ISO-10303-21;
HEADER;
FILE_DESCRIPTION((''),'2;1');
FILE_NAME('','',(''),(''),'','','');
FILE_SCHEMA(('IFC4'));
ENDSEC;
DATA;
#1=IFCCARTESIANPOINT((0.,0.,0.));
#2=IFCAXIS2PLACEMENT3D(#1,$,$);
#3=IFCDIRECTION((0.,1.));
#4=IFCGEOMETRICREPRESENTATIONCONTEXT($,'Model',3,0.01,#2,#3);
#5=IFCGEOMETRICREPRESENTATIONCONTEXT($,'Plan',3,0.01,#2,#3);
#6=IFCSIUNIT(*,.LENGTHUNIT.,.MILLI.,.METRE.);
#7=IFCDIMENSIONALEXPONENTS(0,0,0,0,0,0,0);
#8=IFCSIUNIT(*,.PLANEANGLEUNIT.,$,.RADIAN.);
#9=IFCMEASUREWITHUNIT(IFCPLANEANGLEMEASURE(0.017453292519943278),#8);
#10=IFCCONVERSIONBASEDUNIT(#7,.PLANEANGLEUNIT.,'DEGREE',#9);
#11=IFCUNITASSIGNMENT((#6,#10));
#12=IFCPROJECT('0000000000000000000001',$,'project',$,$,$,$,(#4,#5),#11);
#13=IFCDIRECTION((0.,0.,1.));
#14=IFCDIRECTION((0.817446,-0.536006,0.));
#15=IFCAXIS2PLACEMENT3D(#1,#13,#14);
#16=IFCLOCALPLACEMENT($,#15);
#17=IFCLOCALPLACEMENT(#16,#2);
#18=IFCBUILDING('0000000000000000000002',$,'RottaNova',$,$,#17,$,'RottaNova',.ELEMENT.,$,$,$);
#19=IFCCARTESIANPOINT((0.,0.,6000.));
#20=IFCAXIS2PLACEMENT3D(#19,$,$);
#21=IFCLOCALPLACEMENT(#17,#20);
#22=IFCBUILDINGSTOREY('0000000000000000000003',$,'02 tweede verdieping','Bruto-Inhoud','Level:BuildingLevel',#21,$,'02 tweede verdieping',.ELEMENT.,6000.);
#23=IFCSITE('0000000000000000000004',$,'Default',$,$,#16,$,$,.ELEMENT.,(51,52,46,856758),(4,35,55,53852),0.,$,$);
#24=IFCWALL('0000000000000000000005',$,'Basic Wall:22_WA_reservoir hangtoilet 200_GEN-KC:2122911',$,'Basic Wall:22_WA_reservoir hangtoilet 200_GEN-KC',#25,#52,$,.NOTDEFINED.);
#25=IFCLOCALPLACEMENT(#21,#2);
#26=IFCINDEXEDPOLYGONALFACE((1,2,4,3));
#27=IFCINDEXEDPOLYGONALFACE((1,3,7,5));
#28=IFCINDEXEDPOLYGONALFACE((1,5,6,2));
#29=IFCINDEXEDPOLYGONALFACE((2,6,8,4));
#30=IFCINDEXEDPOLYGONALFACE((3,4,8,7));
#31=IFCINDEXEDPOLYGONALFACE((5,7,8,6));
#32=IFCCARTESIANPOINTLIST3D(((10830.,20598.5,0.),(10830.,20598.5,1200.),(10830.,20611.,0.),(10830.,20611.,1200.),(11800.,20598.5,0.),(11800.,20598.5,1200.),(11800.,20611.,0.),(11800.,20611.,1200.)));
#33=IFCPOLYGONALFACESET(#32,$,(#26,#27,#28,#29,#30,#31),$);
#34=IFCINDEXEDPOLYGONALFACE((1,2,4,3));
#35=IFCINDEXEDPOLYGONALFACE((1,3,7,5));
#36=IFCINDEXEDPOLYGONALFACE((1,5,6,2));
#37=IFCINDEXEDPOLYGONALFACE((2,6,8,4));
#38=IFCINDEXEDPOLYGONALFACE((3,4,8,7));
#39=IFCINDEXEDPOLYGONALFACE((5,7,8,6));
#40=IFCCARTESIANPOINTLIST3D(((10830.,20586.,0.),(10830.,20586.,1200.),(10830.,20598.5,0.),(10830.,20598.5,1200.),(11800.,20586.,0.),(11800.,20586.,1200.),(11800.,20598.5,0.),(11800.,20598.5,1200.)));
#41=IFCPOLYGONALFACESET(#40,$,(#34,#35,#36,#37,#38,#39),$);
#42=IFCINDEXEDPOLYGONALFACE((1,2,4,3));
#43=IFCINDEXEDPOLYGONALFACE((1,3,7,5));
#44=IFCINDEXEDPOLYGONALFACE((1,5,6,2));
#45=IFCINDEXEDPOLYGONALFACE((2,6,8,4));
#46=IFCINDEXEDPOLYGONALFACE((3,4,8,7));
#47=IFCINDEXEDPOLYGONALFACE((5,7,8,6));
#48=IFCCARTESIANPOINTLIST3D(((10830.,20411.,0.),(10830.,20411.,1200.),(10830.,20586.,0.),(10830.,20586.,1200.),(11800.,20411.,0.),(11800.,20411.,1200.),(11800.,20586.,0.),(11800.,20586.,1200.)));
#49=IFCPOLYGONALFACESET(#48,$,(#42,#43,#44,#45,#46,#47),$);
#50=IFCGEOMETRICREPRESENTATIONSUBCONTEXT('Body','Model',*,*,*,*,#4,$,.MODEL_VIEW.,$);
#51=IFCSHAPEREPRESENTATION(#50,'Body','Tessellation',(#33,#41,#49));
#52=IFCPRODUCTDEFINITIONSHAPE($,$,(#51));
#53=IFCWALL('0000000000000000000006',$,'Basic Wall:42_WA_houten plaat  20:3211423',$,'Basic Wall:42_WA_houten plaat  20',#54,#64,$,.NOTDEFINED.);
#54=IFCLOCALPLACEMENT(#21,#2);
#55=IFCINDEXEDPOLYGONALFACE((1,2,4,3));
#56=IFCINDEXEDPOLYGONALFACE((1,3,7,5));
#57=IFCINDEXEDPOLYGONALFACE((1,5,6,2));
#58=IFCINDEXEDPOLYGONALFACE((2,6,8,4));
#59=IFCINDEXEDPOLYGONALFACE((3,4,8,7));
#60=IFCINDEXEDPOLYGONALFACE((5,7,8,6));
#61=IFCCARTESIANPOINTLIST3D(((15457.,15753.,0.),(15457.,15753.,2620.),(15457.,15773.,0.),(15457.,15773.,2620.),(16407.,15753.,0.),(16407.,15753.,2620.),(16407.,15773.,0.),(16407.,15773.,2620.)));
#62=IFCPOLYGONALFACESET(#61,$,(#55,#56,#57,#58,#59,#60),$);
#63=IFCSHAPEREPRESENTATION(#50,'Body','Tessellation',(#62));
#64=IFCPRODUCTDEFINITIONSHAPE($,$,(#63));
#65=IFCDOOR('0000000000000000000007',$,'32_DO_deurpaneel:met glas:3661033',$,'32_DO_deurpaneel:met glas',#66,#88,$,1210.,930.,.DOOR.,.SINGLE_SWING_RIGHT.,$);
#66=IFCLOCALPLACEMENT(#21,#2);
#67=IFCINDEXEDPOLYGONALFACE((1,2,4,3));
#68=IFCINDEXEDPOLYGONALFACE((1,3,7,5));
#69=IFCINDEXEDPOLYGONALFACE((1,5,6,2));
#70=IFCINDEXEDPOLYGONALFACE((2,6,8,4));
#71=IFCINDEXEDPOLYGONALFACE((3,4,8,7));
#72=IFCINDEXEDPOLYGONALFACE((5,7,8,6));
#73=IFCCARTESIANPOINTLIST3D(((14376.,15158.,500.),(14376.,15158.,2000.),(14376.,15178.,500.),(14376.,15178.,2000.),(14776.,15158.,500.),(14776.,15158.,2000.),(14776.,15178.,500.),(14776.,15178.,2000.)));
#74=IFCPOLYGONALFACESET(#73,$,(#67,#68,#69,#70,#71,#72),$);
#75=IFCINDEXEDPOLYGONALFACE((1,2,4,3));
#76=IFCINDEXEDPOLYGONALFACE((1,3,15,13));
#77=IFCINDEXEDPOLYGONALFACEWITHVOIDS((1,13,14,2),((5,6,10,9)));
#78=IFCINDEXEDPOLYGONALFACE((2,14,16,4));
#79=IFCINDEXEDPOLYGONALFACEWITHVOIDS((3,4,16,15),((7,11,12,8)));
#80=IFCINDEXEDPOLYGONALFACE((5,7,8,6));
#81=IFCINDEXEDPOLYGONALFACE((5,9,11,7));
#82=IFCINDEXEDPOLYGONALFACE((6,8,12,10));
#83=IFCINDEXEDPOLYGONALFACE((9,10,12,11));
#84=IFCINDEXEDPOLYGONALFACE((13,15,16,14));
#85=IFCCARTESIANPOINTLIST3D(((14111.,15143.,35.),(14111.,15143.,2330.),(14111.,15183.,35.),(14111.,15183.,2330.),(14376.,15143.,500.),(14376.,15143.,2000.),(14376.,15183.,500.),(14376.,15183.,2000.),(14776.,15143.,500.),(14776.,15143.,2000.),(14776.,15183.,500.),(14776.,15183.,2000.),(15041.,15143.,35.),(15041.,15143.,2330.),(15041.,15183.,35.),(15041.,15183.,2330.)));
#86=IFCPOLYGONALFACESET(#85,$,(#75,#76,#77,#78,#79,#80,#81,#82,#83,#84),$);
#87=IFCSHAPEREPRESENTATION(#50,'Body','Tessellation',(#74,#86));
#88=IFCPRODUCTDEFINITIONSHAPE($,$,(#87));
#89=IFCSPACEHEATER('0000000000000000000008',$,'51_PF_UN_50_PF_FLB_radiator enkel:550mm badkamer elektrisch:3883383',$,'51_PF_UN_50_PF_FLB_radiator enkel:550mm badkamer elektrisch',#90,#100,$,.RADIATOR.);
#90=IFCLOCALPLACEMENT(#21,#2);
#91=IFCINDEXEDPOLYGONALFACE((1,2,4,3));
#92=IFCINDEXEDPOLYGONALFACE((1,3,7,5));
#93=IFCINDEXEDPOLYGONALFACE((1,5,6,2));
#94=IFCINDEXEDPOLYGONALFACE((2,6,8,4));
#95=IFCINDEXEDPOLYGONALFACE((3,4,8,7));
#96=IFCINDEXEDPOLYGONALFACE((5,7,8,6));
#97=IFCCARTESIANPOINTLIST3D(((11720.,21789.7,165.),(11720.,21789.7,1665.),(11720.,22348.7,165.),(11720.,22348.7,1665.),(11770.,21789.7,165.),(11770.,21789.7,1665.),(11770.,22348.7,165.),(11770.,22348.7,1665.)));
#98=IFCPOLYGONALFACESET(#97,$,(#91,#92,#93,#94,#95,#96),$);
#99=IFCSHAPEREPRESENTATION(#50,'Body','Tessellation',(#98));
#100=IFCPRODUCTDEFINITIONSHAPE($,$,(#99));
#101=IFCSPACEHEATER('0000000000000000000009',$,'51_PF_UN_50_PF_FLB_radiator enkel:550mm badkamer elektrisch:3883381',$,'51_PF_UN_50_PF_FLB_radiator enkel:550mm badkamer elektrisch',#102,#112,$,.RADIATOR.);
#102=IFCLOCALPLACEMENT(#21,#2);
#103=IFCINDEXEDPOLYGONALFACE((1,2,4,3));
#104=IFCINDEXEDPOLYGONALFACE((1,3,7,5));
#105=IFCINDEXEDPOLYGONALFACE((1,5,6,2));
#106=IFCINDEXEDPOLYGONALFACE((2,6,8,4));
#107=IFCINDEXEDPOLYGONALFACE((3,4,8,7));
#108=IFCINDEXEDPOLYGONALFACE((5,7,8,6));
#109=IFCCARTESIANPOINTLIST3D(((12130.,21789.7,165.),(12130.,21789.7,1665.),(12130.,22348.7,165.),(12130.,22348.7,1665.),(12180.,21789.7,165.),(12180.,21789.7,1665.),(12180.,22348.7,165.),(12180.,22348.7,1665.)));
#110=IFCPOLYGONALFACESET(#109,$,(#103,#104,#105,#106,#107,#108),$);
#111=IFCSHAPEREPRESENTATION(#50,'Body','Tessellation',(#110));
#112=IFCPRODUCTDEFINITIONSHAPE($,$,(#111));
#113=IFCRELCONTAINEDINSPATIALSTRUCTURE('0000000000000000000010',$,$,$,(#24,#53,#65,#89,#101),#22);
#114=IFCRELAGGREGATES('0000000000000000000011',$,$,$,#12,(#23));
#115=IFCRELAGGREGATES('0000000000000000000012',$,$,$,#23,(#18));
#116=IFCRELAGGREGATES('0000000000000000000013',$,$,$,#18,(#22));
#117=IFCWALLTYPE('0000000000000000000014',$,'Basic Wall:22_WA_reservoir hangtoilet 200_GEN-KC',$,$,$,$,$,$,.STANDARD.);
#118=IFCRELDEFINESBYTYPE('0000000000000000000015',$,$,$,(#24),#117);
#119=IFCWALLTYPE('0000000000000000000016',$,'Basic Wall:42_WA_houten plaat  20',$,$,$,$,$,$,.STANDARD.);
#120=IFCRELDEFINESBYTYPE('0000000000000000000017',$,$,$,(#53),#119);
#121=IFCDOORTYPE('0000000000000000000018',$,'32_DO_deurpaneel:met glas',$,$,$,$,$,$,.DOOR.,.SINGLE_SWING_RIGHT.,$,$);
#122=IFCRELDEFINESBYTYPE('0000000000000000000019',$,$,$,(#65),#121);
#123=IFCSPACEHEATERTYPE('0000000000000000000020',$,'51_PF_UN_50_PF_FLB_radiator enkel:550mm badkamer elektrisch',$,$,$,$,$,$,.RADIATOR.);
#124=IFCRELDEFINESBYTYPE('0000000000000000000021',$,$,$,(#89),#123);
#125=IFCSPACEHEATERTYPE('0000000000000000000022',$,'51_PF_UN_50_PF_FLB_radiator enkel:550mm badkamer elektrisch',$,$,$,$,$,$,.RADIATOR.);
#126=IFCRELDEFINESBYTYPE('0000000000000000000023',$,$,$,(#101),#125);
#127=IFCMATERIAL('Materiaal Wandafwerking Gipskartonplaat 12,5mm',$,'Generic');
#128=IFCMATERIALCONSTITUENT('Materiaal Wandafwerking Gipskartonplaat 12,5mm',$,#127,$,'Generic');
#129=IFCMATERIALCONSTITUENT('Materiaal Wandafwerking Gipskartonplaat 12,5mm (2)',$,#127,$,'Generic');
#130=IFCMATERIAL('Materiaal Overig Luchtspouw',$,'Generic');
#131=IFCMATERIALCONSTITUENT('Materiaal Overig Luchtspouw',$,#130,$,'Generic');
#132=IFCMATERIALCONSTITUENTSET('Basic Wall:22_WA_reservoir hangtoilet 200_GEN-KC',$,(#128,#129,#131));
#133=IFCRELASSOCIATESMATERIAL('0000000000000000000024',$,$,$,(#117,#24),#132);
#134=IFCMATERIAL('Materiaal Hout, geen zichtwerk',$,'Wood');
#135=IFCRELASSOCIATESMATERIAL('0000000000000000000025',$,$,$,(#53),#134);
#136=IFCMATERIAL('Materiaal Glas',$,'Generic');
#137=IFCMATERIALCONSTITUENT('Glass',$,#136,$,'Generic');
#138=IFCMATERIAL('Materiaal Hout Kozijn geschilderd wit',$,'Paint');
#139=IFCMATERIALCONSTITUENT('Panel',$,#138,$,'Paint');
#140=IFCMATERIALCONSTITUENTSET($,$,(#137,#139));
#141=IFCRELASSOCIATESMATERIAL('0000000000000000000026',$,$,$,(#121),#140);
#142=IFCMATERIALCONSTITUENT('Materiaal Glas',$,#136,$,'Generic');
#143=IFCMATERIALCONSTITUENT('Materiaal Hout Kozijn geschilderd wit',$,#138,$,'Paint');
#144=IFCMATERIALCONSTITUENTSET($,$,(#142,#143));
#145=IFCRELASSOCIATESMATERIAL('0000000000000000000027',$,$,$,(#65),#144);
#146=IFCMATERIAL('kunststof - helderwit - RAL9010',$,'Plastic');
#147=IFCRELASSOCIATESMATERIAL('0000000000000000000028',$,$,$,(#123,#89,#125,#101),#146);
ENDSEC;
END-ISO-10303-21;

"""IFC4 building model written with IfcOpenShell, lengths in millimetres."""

from ifc_helpers import new_model, entity, si_unit, converted_unit, direction, frame, origin, place, context, subcontext, project, spatial, indexed_curve, outline, extrude, source, transform, mapped, material, constituent, constituent_set, type_object, type_shapes, element, save


model = new_model("IFC4")

# Units and contexts
model_context = context("Model", 3, precision=0.01, world=origin(), true_north=direction((0.0, 1.0)))
plan_context = context("Plan", 3, precision=0.01, world=origin(), true_north=direction((0.0, 1.0)))
body_context = subcontext(model_context, "Body", "Model", "MODEL_VIEW")
ifc_project = project(units=[si_unit("LENGTHUNIT", "METRE", prefix="MILLI"), converted_unit("PLANEANGLEUNIT", "DEGREE", entity("IfcPlaneAngleMeasure", 0.017453292519943278), si_unit("PLANEANGLEUNIT", "RADIAN"), dimensions=[0, 0, 0, 0, 0, 0, 0])], contexts=[model_context, plan_context])

# Site, building, storey
site_placement = place(None, frame((0.0, 0.0, 0.0), z_axis=(0.0, 0.0, 1.0), x_axis=(0.817446, -0.536006, 0.0)))
site = spatial("IfcSite", under=ifc_project, at=site_placement, Name="Default", CompositionType="ELEMENT", RefLatitude=(51, 52, 46, 856758), RefLongitude=(4, 35, 55, 53852), RefElevation=0.0)
building_placement = place(site_placement, origin())
building = spatial("IfcBuilding", under=site, at=building_placement, Name="RottaNova", LongName="RottaNova", CompositionType="ELEMENT")
storey_placement = place(building_placement, frame((0.0, 0.0, 6000.0)))
storey = spatial("IfcBuildingStorey", under=building, at=storey_placement, Name="02 tweede verdieping", Description="Bruto-Inhoud", ObjectType="Level:BuildingLevel", LongName="02 tweede verdieping", CompositionType="ELEMENT", Elevation=6000.0)

# Walls
ifc_material_1 = material(Name="Materiaal Wandafwerking Gipskartonplaat 12,5mm", Category="Generic")
ifc_constituent_1 = constituent(ifc_material_1, Name="Materiaal Wandafwerking Gipskartonplaat 12,5mm", Category="Generic")
ifc_constituent_2 = constituent(ifc_material_1, Name="Materiaal Wandafwerking Gipskartonplaat 12,5mm (2)", Category="Generic")
ifc_material_2 = material(Name="Materiaal Overig Luchtspouw", Category="Generic")
ifc_constituent_3 = constituent(ifc_material_2, Name="Materiaal Overig Luchtspouw", Category="Generic")
ifc_constituent_set_1 = constituent_set(constituents=[ifc_constituent_1, ifc_constituent_2, ifc_constituent_3], Name="Basic Wall:22_WA_reservoir hangtoilet 200_GEN-KC")
wall_type_1 = type_object("IfcWallType", Name="Basic Wall:22_WA_reservoir hangtoilet 200_GEN-KC", PredefinedType="STANDARD", material=ifc_constituent_set_1)
wall_1_placement = place(storey_placement, frame((10830.0, 20511.0, 0.0)))
element("IfcWall", 1, at=wall_1_placement, inside=storey, type_object=wall_type_1, material=ifc_constituent_set_1, Name="Basic Wall:22_WA_reservoir hangtoilet 200_GEN-KC:2122911", ObjectType="Basic Wall:22_WA_reservoir hangtoilet 200_GEN-KC", PredefinedType="NOTDEFINED", context=body_context, shape_type="SweptSolid", body=[
    extrude(outline(indexed_curve([(-6.3, -485.0), (6.2, -485.0), (6.3, 485.0), (-6.2, 485.0), (-6.3, -485.0)], self_intersect=False)), frame((485.0, 93.8, 0.0), z_axis=(0.0, 0.0, 1.0), x_axis=(0.0, -1.0, 0.0)), (0.0, 0.0, 1.0), 1200.0),
    extrude(outline(indexed_curve([(-485.0, -6.2), (485.0, -6.2), (485.0, 6.3), (-485.0, 6.3), (-485.0, -6.2)], self_intersect=False)), frame((485.0, 81.2, 0.0)), (0.0, 0.0, 1.0), 1200.0),
    extrude(outline(indexed_curve([(-87.5, -485.0), (87.5, -485.0), (87.5, 485.0), (-87.5, 485.0), (-87.5, -485.0)], self_intersect=False)), frame((485.0, -12.5, 0.0), z_axis=(0.0, 0.0, 1.0), x_axis=(0.0, 1.0, 0.0)), (0.0, 0.0, 1.0), 1200.0),
])
ifc_material_3 = material(Name="Materiaal Hout, geen zichtwerk", Category="Wood")
wall_type_2 = type_object("IfcWallType", Name="Basic Wall:42_WA_houten plaat  20", PredefinedType="STANDARD")
wall_2_placement = place(storey_placement, frame((16407.0, 15763.0, 0.0), z_axis=(0.0, 0.0, 1.0), x_axis=(-1.0, 0.0, 0.0)))
element("IfcWall", 2, at=wall_2_placement, inside=storey, type_object=wall_type_2, material=ifc_material_3, Name="Basic Wall:42_WA_houten plaat  20:3211423", ObjectType="Basic Wall:42_WA_houten plaat  20", PredefinedType="NOTDEFINED", context=body_context, shape_type="SweptSolid", body=[
    extrude(outline(indexed_curve([(950.0, 10.0), (0.0, 10.0), (0.0, -10.0), (950.0, -10.0), (950.0, 10.0)], self_intersect=False)), origin(), (0.0, 0.0, 1.0), 2620.0),
])

# Door
ifc_material_4 = material(Name="Materiaal Glas", Category="Generic")
ifc_constituent_4 = constituent(ifc_material_4, Name="Materiaal Glas", Category="Generic")
ifc_material_5 = material(Name="Materiaal Hout Kozijn geschilderd wit", Category="Paint")
ifc_constituent_5 = constituent(ifc_material_5, Name="Materiaal Hout Kozijn geschilderd wit", Category="Paint")
ifc_constituent_set_2 = constituent_set(constituents=[ifc_constituent_4, ifc_constituent_5])
ifc_constituent_6 = constituent(ifc_material_4, Name="Glass", Category="Generic")
ifc_constituent_7 = constituent(ifc_material_5, Name="Panel", Category="Paint")
ifc_constituent_set_3 = constituent_set(constituents=[ifc_constituent_6, ifc_constituent_7])
door_type = type_object("IfcDoorType", Name="32_DO_deurpaneel:met glas", OperationType="SINGLE_SWING_RIGHT", PredefinedType="DOOR", material=ifc_constituent_set_3)
shared_shape_1 = source(origin(), body_context, "Body", "SweptSolid", [
    extrude(outline(indexed_curve([(-10.0, -200.0), (10.0, -200.0), (10.0, 200.0), (-10.0, 200.0), (-10.0, -200.0)], self_intersect=False)), frame((0.0, 25.0, 500.0), z_axis=(0.0, 0.0, 1.0), x_axis=(0.0, 1.0, 0.0)), (0.0, 0.0, 1.0), 1500.0),
    extrude(outline(indexed_curve([(-1147.5, -465.0), (1147.5, -465.0), (1147.5, 465.0), (-1147.5, 465.0), (-1147.5, -465.0)], self_intersect=False), holes=[indexed_curve([(817.5, -200.0), (-682.5, -200.0), (-682.5, 200.0), (817.5, 200.0), (817.5, -200.0)], self_intersect=False)]), frame((0.0, 0.0, 1182.5), z_axis=(0.0, 1.0, 0.0), x_axis=(0.0, 0.0, 1.0)), (0.0, 0.0, 1.0), 40.0),
])
type_shapes(door_type, [shared_shape_1])
door_placement = place(storey_placement, frame((14576.0, 15143.0, 0.0)))
element("IfcDoor", 3, at=door_placement, inside=storey, type_object=door_type, material=ifc_constituent_set_2, Name="32_DO_deurpaneel:met glas:3661033", ObjectType="32_DO_deurpaneel:met glas", OperationType="SINGLE_SWING_RIGHT", OverallHeight=1210.0, OverallWidth=930.0, PredefinedType="DOOR", context=body_context, shape_type="MappedRepresentation", body=[
    mapped(shared_shape_1, transform((0.0, 0.0, 0.0), scale=1.0)),
])

# Space heaters
ifc_material_6 = material(Name="kunststof - helderwit - RAL9010", Category="Plastic")
space_heater_type_1 = type_object("IfcSpaceHeaterType", Name="51_PF_UN_50_PF_FLB_radiator enkel:550mm badkamer elektrisch", PredefinedType="RADIATOR", material=ifc_material_6)
shared_shape_2 = source(origin(), body_context, "Body", "SweptSolid", [
    extrude(outline(indexed_curve([(-279.5, -25.0), (279.5, -25.0), (279.5, 25.0), (-279.5, 25.0), (-279.5, -25.0)], self_intersect=False)), frame((0.0, 75.0, 150.0), z_axis=(0.0, 0.0, 1.0), x_axis=(-1.0, 0.0, 0.0)), (0.0, 0.0, 1.0), 1500.0),
])
type_shapes(space_heater_type_1, [shared_shape_2])
space_heater_1_placement = place(storey_placement, frame((11670.0, 22069.2, 15.0), z_axis=(0.0, 0.0, 1.0), x_axis=(0.0, -1.0, 0.0)))
element("IfcSpaceHeater", 4, at=space_heater_1_placement, inside=storey, type_object=space_heater_type_1, material=ifc_material_6, Name="51_PF_UN_50_PF_FLB_radiator enkel:550mm badkamer elektrisch:3883383", ObjectType="51_PF_UN_50_PF_FLB_radiator enkel:550mm badkamer elektrisch", PredefinedType="RADIATOR", context=body_context, shape_type="MappedRepresentation", body=[
    mapped(shared_shape_2, transform((0.0, 0.0, 0.0), scale=1.0)),
])
space_heater_type_2 = type_object("IfcSpaceHeaterType", Name="51_PF_UN_50_PF_FLB_radiator enkel:550mm badkamer elektrisch", PredefinedType="RADIATOR", material=ifc_material_6)
shared_shape_3 = source(origin(), body_context, "Body", "SweptSolid", [
    extrude(outline(indexed_curve([(-25.0, -279.5), (25.0, -279.5), (25.0, 279.5), (-25.0, 279.5), (-25.0, -279.5)], self_intersect=False)), frame((0.0, -75.0, 150.0), z_axis=(0.0, 0.0, 1.0), x_axis=(0.0, 1.0, 0.0)), (0.0, 0.0, 1.0), 1500.0),
])
type_shapes(space_heater_type_2, [shared_shape_3])
space_heater_2_placement = place(storey_placement, frame((12230.0, 22069.2, 15.0), z_axis=(0.0, 0.0, 1.0), x_axis=(0.0, -1.0, 0.0)))
element("IfcSpaceHeater", 5, at=space_heater_2_placement, inside=storey, type_object=space_heater_type_2, material=ifc_material_6, Name="51_PF_UN_50_PF_FLB_radiator enkel:550mm badkamer elektrisch:3883381", ObjectType="51_PF_UN_50_PF_FLB_radiator enkel:550mm badkamer elektrisch", PredefinedType="RADIATOR", context=body_context, shape_type="MappedRepresentation", body=[
    mapped(shared_shape_3, transform((0.0, 0.0, 0.0), scale=1.0)),
])

save(model, "model.ifc")
